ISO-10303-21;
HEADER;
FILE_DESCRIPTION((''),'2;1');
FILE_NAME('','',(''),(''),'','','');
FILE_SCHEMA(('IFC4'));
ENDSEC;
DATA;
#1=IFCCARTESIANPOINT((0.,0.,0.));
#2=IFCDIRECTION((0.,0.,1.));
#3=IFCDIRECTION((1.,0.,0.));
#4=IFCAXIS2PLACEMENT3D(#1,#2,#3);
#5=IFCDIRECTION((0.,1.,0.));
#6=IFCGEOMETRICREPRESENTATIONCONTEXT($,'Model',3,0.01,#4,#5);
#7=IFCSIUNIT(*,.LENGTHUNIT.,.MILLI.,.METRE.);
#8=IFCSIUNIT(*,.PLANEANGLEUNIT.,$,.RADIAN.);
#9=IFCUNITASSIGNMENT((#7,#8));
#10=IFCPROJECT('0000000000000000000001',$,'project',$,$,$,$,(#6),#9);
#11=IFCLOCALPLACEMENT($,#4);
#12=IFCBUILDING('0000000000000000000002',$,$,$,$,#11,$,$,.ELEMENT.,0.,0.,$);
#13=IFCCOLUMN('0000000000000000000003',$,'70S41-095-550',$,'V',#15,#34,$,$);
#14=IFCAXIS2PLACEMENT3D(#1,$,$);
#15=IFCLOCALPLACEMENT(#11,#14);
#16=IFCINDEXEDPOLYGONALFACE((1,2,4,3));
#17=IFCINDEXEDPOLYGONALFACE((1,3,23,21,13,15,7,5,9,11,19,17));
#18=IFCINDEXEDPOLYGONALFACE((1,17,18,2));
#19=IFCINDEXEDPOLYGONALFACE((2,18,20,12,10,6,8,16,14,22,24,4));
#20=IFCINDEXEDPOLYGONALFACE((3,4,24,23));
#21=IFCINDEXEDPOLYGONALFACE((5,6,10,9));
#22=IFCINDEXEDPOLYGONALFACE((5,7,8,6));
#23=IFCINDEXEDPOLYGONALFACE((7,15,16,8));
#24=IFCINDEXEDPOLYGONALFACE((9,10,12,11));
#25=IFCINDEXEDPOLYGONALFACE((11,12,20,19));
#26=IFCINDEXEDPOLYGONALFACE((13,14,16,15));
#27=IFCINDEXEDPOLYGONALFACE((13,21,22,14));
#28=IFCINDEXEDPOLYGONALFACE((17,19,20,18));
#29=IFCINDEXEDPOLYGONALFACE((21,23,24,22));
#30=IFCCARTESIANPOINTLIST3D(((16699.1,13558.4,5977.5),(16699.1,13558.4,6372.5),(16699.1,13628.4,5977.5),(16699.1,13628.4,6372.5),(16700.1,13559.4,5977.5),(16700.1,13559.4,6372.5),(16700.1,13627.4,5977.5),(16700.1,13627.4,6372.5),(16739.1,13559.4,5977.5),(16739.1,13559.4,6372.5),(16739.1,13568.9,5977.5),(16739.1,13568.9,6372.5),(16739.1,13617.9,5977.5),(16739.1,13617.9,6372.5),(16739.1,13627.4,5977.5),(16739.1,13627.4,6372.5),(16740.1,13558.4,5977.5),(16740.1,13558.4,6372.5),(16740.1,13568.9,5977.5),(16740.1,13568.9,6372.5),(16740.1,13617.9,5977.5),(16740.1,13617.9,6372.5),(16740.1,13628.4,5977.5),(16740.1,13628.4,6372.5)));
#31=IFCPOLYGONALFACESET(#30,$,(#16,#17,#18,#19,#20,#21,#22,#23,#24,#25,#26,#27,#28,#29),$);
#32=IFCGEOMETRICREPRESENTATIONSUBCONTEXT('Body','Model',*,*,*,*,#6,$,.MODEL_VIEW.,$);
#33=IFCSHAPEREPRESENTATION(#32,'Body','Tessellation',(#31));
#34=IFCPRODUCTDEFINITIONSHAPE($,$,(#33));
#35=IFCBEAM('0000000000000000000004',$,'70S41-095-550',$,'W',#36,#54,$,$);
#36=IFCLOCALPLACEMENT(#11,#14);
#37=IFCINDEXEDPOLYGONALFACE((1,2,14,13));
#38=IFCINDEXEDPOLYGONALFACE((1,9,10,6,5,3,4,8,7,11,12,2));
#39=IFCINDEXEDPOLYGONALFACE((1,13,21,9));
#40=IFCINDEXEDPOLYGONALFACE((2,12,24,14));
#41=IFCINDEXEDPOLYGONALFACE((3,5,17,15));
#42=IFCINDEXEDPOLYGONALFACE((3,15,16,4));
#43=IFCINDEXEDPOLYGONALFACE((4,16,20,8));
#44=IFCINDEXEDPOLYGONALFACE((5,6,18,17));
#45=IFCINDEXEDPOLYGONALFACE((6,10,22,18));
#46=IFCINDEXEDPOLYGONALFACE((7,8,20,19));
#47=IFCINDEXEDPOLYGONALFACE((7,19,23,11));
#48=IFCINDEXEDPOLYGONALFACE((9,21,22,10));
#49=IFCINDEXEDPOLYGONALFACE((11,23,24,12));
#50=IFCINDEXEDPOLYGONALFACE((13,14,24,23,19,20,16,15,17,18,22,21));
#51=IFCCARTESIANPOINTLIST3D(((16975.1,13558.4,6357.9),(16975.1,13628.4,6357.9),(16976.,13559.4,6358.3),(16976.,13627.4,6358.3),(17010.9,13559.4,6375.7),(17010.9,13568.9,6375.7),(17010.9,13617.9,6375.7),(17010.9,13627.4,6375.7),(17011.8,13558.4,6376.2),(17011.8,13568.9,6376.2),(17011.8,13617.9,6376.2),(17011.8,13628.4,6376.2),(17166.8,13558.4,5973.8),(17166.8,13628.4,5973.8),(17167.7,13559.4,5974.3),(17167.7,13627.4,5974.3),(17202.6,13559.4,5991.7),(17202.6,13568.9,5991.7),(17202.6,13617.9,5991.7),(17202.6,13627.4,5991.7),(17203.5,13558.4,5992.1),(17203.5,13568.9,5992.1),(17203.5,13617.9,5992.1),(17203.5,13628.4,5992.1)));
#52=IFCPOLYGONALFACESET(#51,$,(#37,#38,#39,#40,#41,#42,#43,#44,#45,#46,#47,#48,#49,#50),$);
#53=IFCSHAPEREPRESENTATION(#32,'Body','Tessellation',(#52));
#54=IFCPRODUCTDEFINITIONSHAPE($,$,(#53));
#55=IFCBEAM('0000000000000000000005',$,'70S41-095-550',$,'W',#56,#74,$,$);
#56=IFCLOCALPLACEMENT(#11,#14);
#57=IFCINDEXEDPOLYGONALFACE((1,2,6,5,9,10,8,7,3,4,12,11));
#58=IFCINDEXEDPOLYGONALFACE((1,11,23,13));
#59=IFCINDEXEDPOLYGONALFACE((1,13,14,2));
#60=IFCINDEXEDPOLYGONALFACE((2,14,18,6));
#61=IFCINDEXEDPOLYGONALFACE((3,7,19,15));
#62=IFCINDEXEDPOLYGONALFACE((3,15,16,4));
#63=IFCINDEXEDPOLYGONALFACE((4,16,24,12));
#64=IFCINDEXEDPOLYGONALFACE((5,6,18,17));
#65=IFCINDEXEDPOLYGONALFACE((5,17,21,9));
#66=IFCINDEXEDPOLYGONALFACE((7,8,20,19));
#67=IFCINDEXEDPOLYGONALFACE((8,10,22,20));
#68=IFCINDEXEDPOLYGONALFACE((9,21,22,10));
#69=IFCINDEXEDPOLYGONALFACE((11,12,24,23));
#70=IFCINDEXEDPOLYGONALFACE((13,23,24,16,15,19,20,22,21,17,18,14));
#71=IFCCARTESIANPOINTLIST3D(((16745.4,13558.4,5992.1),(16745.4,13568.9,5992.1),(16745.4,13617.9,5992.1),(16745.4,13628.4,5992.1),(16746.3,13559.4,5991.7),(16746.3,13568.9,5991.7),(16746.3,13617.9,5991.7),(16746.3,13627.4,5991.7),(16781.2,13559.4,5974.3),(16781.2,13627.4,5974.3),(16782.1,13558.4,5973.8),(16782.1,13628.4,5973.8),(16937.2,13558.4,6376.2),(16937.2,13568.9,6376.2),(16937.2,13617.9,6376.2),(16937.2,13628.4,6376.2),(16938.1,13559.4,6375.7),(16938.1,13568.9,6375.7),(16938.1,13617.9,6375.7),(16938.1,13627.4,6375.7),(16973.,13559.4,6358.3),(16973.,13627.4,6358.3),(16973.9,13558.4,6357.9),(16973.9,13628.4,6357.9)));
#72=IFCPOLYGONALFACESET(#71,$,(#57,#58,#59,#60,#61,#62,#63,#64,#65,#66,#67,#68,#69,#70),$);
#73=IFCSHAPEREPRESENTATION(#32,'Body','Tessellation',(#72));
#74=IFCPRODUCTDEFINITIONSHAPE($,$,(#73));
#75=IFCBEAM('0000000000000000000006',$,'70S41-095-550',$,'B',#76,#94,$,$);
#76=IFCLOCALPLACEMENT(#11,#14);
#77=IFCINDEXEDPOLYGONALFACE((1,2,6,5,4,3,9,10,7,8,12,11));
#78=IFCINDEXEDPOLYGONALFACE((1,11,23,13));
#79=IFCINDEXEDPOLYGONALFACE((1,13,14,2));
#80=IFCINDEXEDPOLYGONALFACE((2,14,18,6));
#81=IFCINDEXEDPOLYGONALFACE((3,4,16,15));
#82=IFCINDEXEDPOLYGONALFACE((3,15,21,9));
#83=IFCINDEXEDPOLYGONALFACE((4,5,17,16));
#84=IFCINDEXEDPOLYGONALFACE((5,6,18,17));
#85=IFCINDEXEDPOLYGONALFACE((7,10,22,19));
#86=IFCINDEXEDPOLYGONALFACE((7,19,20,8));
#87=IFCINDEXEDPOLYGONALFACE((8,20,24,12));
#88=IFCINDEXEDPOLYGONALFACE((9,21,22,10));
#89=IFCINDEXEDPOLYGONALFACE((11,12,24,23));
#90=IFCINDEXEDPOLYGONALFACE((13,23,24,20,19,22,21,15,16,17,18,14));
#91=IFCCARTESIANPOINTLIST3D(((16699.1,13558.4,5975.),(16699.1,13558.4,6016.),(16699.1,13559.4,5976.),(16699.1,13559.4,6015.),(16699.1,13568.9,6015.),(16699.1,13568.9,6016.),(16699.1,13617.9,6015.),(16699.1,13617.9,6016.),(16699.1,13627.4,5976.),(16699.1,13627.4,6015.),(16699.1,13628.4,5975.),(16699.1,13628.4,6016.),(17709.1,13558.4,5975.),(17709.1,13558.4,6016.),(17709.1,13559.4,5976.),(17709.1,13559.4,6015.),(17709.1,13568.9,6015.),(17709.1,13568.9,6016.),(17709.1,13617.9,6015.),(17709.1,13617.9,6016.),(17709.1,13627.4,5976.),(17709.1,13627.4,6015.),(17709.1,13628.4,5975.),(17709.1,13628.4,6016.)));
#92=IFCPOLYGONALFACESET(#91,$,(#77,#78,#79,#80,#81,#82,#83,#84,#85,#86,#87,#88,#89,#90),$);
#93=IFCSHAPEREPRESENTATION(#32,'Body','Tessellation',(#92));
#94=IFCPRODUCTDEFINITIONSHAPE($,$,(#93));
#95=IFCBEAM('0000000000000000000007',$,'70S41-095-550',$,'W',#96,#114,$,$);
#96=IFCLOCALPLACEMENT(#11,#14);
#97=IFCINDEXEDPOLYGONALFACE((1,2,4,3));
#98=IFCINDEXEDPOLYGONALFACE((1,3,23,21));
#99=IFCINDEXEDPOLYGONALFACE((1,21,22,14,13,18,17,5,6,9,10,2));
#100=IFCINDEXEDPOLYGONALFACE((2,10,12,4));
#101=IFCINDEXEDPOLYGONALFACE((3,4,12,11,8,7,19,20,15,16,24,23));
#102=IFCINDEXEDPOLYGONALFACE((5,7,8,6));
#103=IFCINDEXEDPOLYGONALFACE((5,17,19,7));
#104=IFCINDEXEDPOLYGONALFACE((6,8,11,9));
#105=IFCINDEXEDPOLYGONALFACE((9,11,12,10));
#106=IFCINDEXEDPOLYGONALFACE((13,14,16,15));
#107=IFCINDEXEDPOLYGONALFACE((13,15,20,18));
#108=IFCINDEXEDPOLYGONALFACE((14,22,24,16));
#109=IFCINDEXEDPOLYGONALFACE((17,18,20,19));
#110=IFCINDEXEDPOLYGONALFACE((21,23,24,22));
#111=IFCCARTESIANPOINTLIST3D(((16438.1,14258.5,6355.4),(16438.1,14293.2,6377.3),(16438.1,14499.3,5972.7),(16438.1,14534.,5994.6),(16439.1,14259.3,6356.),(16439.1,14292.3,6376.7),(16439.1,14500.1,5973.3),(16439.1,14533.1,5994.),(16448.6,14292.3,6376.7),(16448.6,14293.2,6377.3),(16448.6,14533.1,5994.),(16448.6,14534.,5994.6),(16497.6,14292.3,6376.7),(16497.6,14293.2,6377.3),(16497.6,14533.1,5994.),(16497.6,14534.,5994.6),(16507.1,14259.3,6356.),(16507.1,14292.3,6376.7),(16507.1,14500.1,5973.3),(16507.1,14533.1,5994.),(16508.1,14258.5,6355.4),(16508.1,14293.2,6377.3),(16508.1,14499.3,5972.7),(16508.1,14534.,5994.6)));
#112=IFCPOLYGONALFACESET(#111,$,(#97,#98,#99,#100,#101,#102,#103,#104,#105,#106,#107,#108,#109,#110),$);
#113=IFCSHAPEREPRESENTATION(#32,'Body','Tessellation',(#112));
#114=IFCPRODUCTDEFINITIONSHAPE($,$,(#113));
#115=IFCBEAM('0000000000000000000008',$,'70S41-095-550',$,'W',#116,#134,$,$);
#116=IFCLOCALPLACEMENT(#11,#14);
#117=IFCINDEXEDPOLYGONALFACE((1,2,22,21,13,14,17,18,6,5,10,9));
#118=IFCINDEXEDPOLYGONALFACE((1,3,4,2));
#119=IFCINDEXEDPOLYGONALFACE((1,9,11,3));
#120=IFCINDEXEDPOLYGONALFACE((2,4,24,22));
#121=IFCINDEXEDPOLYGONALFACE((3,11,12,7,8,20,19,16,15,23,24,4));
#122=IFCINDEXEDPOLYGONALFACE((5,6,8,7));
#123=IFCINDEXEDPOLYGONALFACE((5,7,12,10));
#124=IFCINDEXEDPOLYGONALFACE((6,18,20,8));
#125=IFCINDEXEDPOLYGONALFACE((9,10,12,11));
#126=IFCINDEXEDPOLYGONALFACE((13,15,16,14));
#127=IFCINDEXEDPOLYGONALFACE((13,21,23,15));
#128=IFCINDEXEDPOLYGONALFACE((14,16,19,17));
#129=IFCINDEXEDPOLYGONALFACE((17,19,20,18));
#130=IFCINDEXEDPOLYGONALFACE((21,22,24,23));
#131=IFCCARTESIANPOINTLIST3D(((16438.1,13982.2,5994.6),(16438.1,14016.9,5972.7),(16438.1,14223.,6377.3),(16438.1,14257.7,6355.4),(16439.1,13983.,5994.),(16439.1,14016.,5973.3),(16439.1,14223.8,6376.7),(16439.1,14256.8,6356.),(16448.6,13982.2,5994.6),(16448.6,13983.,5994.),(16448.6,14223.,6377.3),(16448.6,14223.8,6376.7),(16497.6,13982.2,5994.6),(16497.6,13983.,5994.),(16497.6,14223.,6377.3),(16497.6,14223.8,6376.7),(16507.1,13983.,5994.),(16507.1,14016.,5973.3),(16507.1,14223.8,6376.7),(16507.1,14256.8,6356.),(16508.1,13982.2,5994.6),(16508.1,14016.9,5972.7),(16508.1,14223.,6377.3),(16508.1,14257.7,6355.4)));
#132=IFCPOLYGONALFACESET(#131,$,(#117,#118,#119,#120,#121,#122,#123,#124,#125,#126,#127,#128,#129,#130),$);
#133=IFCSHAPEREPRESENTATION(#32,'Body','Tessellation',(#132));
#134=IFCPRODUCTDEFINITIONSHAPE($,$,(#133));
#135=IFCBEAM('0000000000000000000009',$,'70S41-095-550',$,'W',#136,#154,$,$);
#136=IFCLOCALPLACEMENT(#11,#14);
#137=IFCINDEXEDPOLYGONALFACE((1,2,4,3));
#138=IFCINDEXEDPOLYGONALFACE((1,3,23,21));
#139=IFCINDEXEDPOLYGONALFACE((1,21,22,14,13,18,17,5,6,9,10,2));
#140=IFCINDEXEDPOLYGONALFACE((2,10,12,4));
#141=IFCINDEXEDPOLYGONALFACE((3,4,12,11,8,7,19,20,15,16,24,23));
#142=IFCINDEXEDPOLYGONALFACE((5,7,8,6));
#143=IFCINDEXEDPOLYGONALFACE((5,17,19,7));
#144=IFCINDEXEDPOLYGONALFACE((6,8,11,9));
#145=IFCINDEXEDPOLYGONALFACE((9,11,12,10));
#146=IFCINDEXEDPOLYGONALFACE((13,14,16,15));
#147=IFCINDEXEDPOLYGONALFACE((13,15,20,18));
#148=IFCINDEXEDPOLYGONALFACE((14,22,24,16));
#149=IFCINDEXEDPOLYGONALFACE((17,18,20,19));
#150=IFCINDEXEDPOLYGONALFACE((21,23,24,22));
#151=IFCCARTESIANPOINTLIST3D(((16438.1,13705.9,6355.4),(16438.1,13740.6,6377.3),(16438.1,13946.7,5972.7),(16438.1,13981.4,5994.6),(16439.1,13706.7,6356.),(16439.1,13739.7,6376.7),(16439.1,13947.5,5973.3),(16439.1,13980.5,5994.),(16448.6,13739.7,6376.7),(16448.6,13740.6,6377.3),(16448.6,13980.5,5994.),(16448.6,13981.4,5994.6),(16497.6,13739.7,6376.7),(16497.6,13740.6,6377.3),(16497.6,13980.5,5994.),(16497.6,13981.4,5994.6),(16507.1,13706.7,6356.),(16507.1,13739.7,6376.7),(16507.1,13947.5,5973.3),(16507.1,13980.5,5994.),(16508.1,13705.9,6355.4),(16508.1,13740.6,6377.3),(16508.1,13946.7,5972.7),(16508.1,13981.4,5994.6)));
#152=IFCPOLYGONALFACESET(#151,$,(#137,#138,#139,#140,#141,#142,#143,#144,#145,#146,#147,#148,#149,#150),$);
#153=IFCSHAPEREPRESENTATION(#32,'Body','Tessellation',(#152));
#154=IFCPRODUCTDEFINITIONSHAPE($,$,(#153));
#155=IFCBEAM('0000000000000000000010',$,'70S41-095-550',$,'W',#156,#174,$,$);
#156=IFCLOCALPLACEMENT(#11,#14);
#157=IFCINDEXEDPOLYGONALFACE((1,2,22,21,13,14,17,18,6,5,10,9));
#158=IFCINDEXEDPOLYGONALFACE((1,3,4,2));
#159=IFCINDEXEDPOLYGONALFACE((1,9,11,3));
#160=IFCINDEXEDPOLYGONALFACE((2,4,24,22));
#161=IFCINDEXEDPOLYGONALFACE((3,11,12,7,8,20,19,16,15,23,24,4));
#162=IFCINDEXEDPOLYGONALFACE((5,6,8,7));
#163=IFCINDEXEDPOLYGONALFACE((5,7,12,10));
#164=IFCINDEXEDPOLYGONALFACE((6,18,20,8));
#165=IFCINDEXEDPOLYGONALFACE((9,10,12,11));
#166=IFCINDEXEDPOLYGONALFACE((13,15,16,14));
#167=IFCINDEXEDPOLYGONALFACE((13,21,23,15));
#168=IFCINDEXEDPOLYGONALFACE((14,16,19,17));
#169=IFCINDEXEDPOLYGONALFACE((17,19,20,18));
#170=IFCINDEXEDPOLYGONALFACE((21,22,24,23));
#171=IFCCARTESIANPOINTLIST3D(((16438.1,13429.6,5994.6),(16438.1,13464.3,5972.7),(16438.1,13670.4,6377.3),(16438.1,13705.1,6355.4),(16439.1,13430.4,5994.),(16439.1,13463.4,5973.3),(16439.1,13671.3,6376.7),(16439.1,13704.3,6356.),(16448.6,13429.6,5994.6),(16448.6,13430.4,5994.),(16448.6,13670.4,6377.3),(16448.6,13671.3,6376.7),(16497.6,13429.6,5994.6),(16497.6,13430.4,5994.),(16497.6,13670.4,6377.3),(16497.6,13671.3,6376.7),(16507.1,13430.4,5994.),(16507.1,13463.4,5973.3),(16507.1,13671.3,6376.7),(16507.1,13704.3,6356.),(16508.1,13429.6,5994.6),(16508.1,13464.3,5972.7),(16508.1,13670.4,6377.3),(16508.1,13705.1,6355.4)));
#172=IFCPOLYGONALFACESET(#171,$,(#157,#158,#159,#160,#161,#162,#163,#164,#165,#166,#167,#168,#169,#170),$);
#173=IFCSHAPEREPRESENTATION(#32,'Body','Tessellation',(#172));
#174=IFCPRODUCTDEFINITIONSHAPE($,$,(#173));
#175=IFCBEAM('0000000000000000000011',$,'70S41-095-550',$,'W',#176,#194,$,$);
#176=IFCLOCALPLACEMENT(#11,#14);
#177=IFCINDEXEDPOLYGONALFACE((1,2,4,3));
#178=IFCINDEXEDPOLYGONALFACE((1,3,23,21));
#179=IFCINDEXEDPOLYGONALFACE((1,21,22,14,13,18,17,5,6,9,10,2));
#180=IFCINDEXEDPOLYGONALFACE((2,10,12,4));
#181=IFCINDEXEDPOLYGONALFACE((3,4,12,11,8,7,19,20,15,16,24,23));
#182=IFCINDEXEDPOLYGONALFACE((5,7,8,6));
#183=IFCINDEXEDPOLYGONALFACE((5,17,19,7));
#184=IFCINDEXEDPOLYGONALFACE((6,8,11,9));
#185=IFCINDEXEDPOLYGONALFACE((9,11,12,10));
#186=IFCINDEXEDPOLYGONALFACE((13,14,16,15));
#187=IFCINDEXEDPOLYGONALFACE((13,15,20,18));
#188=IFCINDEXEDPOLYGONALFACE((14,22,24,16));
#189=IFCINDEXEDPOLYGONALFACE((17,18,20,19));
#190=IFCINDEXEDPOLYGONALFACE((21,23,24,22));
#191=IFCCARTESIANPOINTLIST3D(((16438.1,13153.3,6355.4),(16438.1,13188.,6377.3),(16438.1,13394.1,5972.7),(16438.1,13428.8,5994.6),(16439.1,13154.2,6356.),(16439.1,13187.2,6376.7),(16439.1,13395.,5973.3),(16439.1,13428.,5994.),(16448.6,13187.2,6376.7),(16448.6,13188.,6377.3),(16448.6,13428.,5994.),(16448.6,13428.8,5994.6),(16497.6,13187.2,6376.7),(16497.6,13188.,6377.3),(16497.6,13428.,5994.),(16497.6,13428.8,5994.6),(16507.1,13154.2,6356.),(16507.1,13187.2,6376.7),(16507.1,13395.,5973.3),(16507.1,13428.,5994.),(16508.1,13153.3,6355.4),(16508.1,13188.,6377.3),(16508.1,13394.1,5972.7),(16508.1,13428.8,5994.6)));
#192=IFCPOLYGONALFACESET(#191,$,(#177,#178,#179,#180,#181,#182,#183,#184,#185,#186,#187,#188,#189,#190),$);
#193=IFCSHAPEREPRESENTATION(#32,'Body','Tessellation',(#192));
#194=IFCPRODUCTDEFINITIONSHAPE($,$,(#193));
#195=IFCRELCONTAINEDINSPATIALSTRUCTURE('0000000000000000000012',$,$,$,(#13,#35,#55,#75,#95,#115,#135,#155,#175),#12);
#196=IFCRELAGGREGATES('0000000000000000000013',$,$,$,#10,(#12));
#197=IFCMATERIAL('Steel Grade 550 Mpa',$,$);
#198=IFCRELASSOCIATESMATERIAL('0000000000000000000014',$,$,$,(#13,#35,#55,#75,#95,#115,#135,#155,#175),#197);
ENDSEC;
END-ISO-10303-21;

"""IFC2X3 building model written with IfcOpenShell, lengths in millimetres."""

from ifc_helpers import new_model, si_unit, direction, frame, origin, origin_with_axes, origin_2d_with_axis, place, context, subcontext, project, spatial, c_section, extrude, source, transform, mapped, material, element, save


model = new_model("IFC2X3")

# Units and contexts
model_context = context("Model", 3, precision=0.01, world=origin_with_axes(), true_north=direction((0.0, 1.0, 0.0)))
body_context = subcontext(model_context, "Body", "Model", "MODEL_VIEW")
ifc_project = project(units=[si_unit("LENGTHUNIT", "METRE", prefix="MILLI"), si_unit("PLANEANGLEUNIT", "RADIAN")], contexts=[model_context])

# Building
building_placement = place(None, origin_with_axes())
building = spatial("IfcBuilding", under=ifc_project, at=building_placement, CompositionType="ELEMENT", ElevationOfRefHeight=0.0, ElevationOfTerrain=0.0)

# Column
ifc_material = material(Name="Steel Grade 550 Mpa")
shared_shape_1 = source(origin(), body_context, "Body", "SweptSolid", [
    extrude(c_section(Depth=70.0, Width=41.0, WallThickness=1.0, Girth=10.5, at=origin_2d_with_axis()), origin_with_axes(), (0.0, 0.0, 1.0), 395.0),
])
column_placement = place(None, frame((16719.6, 13593.4, 6372.5), z_axis=(0.0, 0.0, -1.0), x_axis=(1.0, 0.0, 0.0)))
element("IfcColumn", 1, at=column_placement, inside=building, material=ifc_material, Name="70S41-095-550", ObjectType="V", context=body_context, shape_type="MappedRepresentation", body=[
    mapped(shared_shape_1, transform((0.0, 0.0, 0.0), scale=1.0)),
])

# Beams
shared_shape_2 = source(origin(), body_context, "Body", "SweptSolid", [
    extrude(c_section(Depth=70.0, Width=41.0, WallThickness=1.0, Girth=10.5, at=origin_2d_with_axis()), origin_with_axes(), (0.0, 0.0, 1.0), 429.3),
])
beam_1_placement = place(None, frame((16993.4, 13593.4, 6367.0), z_axis=(0.44675, 0.0, -0.894659), x_axis=(0.894659, 0.0, 0.44675)))
element("IfcBeam", 2, at=beam_1_placement, inside=building, material=ifc_material, Name="70S41-095-550", ObjectType="W", context=body_context, shape_type="MappedRepresentation", body=[
    mapped(shared_shape_2, transform((0.0, 0.0, 0.0), scale=1.0)),
])
shared_shape_3 = source(origin(), body_context, "Body", "SweptSolid", [
    extrude(c_section(Depth=70.0, Width=41.0, WallThickness=1.0, Girth=10.5, at=origin_2d_with_axis()), origin_with_axes(), (0.0, 0.0, 1.0), 429.3),
])
beam_2_placement = place(None, frame((16763.8, 13593.4, 5983.0), z_axis=(0.44675, 0.0, 0.894659), x_axis=(-0.894659, 0.0, 0.44675)))
element("IfcBeam", 3, at=beam_2_placement, inside=building, material=ifc_material, Name="70S41-095-550", ObjectType="W", context=body_context, shape_type="MappedRepresentation", body=[
    mapped(shared_shape_3, transform((0.0, 0.0, 0.0), scale=1.0)),
])
shared_shape_4 = source(origin(), body_context, "Body", "SweptSolid", [
    extrude(c_section(Depth=70.0, Width=41.0, WallThickness=1.0, Girth=10.5, at=origin_2d_with_axis()), origin_with_axes(), (0.0, 0.0, 1.0), 1010.0),
])
beam_3_placement = place(None, frame((16699.1, 13593.4, 5995.5), z_axis=(1.0, 0.0, 0.0), x_axis=(0.0, 0.0, 1.0)))
element("IfcBeam", 4, at=beam_3_placement, inside=building, material=ifc_material, Name="70S41-095-550", ObjectType="B", context=body_context, shape_type="MappedRepresentation", body=[
    mapped(shared_shape_4, transform((0.0, 0.0, 0.0), scale=1.0)),
])
shared_shape_5 = source(origin(), body_context, "Body", "SweptSolid", [
    extrude(c_section(Depth=70.0, Width=41.0, WallThickness=1.0, Girth=10.5, at=origin_2d_with_axis()), origin_with_axes(), (0.0, 0.0, 1.0), 452.2),
])
beam_4_placement = place(None, frame((16473.1, 14275.8, 6366.3), z_axis=(0.0, 0.532581, -0.846379), x_axis=(0.0, 0.846379, 0.532581)))
element("IfcBeam", 5, at=beam_4_placement, inside=building, material=ifc_material, Name="70S41-095-550", ObjectType="W", context=body_context, shape_type="MappedRepresentation", body=[
    mapped(shared_shape_5, transform((0.0, 0.0, 0.0), scale=1.0)),
])
shared_shape_6 = source(origin(), body_context, "Body", "SweptSolid", [
    extrude(c_section(Depth=70.0, Width=41.0, WallThickness=1.0, Girth=10.5, at=origin_2d_with_axis()), origin_with_axes(), (0.0, 0.0, 1.0), 452.2),
])
beam_5_placement = place(None, frame((16473.1, 13999.5, 5983.7), z_axis=(0.0, 0.532581, 0.846379), x_axis=(0.0, -0.846379, 0.532581)))
element("IfcBeam", 6, at=beam_5_placement, inside=building, material=ifc_material, Name="70S41-095-550", ObjectType="W", context=body_context, shape_type="MappedRepresentation", body=[
    mapped(shared_shape_6, transform((0.0, 0.0, 0.0), scale=1.0)),
])
shared_shape_7 = source(origin(), body_context, "Body", "SweptSolid", [
    extrude(c_section(Depth=70.0, Width=41.0, WallThickness=1.0, Girth=10.5, at=origin_2d_with_axis()), origin_with_axes(), (0.0, 0.0, 1.0), 452.2),
])
beam_6_placement = place(None, frame((16473.1, 13723.2, 6366.3), z_axis=(0.0, 0.532581, -0.846379), x_axis=(0.0, 0.846379, 0.532581)))
element("IfcBeam", 7, at=beam_6_placement, inside=building, material=ifc_material, Name="70S41-095-550", ObjectType="W", context=body_context, shape_type="MappedRepresentation", body=[
    mapped(shared_shape_7, transform((0.0, 0.0, 0.0), scale=1.0)),
])
shared_shape_8 = source(origin(), body_context, "Body", "SweptSolid", [
    extrude(c_section(Depth=70.0, Width=41.0, WallThickness=1.0, Girth=10.5, at=origin_2d_with_axis()), origin_with_axes(), (0.0, 0.0, 1.0), 452.2),
])
beam_7_placement = place(None, frame((16473.1, 13446.9, 5983.7), z_axis=(0.0, 0.532581, 0.846379), x_axis=(0.0, -0.846379, 0.532581)))
element("IfcBeam", 8, at=beam_7_placement, inside=building, material=ifc_material, Name="70S41-095-550", ObjectType="W", context=body_context, shape_type="MappedRepresentation", body=[
    mapped(shared_shape_8, transform((0.0, 0.0, 0.0), scale=1.0)),
])
shared_shape_9 = source(origin(), body_context, "Body", "SweptSolid", [
    extrude(c_section(Depth=70.0, Width=41.0, WallThickness=1.0, Girth=10.5, at=origin_2d_with_axis()), origin_with_axes(), (0.0, 0.0, 1.0), 452.2),
])
beam_8_placement = place(None, frame((16473.1, 13170.7, 6366.3), z_axis=(0.0, 0.532581, -0.846379), x_axis=(0.0, 0.846379, 0.532581)))
element("IfcBeam", 9, at=beam_8_placement, inside=building, material=ifc_material, Name="70S41-095-550", ObjectType="W", context=body_context, shape_type="MappedRepresentation", body=[
    mapped(shared_shape_9, transform((0.0, 0.0, 0.0), scale=1.0)),
])

save(model, "model.ifc")
